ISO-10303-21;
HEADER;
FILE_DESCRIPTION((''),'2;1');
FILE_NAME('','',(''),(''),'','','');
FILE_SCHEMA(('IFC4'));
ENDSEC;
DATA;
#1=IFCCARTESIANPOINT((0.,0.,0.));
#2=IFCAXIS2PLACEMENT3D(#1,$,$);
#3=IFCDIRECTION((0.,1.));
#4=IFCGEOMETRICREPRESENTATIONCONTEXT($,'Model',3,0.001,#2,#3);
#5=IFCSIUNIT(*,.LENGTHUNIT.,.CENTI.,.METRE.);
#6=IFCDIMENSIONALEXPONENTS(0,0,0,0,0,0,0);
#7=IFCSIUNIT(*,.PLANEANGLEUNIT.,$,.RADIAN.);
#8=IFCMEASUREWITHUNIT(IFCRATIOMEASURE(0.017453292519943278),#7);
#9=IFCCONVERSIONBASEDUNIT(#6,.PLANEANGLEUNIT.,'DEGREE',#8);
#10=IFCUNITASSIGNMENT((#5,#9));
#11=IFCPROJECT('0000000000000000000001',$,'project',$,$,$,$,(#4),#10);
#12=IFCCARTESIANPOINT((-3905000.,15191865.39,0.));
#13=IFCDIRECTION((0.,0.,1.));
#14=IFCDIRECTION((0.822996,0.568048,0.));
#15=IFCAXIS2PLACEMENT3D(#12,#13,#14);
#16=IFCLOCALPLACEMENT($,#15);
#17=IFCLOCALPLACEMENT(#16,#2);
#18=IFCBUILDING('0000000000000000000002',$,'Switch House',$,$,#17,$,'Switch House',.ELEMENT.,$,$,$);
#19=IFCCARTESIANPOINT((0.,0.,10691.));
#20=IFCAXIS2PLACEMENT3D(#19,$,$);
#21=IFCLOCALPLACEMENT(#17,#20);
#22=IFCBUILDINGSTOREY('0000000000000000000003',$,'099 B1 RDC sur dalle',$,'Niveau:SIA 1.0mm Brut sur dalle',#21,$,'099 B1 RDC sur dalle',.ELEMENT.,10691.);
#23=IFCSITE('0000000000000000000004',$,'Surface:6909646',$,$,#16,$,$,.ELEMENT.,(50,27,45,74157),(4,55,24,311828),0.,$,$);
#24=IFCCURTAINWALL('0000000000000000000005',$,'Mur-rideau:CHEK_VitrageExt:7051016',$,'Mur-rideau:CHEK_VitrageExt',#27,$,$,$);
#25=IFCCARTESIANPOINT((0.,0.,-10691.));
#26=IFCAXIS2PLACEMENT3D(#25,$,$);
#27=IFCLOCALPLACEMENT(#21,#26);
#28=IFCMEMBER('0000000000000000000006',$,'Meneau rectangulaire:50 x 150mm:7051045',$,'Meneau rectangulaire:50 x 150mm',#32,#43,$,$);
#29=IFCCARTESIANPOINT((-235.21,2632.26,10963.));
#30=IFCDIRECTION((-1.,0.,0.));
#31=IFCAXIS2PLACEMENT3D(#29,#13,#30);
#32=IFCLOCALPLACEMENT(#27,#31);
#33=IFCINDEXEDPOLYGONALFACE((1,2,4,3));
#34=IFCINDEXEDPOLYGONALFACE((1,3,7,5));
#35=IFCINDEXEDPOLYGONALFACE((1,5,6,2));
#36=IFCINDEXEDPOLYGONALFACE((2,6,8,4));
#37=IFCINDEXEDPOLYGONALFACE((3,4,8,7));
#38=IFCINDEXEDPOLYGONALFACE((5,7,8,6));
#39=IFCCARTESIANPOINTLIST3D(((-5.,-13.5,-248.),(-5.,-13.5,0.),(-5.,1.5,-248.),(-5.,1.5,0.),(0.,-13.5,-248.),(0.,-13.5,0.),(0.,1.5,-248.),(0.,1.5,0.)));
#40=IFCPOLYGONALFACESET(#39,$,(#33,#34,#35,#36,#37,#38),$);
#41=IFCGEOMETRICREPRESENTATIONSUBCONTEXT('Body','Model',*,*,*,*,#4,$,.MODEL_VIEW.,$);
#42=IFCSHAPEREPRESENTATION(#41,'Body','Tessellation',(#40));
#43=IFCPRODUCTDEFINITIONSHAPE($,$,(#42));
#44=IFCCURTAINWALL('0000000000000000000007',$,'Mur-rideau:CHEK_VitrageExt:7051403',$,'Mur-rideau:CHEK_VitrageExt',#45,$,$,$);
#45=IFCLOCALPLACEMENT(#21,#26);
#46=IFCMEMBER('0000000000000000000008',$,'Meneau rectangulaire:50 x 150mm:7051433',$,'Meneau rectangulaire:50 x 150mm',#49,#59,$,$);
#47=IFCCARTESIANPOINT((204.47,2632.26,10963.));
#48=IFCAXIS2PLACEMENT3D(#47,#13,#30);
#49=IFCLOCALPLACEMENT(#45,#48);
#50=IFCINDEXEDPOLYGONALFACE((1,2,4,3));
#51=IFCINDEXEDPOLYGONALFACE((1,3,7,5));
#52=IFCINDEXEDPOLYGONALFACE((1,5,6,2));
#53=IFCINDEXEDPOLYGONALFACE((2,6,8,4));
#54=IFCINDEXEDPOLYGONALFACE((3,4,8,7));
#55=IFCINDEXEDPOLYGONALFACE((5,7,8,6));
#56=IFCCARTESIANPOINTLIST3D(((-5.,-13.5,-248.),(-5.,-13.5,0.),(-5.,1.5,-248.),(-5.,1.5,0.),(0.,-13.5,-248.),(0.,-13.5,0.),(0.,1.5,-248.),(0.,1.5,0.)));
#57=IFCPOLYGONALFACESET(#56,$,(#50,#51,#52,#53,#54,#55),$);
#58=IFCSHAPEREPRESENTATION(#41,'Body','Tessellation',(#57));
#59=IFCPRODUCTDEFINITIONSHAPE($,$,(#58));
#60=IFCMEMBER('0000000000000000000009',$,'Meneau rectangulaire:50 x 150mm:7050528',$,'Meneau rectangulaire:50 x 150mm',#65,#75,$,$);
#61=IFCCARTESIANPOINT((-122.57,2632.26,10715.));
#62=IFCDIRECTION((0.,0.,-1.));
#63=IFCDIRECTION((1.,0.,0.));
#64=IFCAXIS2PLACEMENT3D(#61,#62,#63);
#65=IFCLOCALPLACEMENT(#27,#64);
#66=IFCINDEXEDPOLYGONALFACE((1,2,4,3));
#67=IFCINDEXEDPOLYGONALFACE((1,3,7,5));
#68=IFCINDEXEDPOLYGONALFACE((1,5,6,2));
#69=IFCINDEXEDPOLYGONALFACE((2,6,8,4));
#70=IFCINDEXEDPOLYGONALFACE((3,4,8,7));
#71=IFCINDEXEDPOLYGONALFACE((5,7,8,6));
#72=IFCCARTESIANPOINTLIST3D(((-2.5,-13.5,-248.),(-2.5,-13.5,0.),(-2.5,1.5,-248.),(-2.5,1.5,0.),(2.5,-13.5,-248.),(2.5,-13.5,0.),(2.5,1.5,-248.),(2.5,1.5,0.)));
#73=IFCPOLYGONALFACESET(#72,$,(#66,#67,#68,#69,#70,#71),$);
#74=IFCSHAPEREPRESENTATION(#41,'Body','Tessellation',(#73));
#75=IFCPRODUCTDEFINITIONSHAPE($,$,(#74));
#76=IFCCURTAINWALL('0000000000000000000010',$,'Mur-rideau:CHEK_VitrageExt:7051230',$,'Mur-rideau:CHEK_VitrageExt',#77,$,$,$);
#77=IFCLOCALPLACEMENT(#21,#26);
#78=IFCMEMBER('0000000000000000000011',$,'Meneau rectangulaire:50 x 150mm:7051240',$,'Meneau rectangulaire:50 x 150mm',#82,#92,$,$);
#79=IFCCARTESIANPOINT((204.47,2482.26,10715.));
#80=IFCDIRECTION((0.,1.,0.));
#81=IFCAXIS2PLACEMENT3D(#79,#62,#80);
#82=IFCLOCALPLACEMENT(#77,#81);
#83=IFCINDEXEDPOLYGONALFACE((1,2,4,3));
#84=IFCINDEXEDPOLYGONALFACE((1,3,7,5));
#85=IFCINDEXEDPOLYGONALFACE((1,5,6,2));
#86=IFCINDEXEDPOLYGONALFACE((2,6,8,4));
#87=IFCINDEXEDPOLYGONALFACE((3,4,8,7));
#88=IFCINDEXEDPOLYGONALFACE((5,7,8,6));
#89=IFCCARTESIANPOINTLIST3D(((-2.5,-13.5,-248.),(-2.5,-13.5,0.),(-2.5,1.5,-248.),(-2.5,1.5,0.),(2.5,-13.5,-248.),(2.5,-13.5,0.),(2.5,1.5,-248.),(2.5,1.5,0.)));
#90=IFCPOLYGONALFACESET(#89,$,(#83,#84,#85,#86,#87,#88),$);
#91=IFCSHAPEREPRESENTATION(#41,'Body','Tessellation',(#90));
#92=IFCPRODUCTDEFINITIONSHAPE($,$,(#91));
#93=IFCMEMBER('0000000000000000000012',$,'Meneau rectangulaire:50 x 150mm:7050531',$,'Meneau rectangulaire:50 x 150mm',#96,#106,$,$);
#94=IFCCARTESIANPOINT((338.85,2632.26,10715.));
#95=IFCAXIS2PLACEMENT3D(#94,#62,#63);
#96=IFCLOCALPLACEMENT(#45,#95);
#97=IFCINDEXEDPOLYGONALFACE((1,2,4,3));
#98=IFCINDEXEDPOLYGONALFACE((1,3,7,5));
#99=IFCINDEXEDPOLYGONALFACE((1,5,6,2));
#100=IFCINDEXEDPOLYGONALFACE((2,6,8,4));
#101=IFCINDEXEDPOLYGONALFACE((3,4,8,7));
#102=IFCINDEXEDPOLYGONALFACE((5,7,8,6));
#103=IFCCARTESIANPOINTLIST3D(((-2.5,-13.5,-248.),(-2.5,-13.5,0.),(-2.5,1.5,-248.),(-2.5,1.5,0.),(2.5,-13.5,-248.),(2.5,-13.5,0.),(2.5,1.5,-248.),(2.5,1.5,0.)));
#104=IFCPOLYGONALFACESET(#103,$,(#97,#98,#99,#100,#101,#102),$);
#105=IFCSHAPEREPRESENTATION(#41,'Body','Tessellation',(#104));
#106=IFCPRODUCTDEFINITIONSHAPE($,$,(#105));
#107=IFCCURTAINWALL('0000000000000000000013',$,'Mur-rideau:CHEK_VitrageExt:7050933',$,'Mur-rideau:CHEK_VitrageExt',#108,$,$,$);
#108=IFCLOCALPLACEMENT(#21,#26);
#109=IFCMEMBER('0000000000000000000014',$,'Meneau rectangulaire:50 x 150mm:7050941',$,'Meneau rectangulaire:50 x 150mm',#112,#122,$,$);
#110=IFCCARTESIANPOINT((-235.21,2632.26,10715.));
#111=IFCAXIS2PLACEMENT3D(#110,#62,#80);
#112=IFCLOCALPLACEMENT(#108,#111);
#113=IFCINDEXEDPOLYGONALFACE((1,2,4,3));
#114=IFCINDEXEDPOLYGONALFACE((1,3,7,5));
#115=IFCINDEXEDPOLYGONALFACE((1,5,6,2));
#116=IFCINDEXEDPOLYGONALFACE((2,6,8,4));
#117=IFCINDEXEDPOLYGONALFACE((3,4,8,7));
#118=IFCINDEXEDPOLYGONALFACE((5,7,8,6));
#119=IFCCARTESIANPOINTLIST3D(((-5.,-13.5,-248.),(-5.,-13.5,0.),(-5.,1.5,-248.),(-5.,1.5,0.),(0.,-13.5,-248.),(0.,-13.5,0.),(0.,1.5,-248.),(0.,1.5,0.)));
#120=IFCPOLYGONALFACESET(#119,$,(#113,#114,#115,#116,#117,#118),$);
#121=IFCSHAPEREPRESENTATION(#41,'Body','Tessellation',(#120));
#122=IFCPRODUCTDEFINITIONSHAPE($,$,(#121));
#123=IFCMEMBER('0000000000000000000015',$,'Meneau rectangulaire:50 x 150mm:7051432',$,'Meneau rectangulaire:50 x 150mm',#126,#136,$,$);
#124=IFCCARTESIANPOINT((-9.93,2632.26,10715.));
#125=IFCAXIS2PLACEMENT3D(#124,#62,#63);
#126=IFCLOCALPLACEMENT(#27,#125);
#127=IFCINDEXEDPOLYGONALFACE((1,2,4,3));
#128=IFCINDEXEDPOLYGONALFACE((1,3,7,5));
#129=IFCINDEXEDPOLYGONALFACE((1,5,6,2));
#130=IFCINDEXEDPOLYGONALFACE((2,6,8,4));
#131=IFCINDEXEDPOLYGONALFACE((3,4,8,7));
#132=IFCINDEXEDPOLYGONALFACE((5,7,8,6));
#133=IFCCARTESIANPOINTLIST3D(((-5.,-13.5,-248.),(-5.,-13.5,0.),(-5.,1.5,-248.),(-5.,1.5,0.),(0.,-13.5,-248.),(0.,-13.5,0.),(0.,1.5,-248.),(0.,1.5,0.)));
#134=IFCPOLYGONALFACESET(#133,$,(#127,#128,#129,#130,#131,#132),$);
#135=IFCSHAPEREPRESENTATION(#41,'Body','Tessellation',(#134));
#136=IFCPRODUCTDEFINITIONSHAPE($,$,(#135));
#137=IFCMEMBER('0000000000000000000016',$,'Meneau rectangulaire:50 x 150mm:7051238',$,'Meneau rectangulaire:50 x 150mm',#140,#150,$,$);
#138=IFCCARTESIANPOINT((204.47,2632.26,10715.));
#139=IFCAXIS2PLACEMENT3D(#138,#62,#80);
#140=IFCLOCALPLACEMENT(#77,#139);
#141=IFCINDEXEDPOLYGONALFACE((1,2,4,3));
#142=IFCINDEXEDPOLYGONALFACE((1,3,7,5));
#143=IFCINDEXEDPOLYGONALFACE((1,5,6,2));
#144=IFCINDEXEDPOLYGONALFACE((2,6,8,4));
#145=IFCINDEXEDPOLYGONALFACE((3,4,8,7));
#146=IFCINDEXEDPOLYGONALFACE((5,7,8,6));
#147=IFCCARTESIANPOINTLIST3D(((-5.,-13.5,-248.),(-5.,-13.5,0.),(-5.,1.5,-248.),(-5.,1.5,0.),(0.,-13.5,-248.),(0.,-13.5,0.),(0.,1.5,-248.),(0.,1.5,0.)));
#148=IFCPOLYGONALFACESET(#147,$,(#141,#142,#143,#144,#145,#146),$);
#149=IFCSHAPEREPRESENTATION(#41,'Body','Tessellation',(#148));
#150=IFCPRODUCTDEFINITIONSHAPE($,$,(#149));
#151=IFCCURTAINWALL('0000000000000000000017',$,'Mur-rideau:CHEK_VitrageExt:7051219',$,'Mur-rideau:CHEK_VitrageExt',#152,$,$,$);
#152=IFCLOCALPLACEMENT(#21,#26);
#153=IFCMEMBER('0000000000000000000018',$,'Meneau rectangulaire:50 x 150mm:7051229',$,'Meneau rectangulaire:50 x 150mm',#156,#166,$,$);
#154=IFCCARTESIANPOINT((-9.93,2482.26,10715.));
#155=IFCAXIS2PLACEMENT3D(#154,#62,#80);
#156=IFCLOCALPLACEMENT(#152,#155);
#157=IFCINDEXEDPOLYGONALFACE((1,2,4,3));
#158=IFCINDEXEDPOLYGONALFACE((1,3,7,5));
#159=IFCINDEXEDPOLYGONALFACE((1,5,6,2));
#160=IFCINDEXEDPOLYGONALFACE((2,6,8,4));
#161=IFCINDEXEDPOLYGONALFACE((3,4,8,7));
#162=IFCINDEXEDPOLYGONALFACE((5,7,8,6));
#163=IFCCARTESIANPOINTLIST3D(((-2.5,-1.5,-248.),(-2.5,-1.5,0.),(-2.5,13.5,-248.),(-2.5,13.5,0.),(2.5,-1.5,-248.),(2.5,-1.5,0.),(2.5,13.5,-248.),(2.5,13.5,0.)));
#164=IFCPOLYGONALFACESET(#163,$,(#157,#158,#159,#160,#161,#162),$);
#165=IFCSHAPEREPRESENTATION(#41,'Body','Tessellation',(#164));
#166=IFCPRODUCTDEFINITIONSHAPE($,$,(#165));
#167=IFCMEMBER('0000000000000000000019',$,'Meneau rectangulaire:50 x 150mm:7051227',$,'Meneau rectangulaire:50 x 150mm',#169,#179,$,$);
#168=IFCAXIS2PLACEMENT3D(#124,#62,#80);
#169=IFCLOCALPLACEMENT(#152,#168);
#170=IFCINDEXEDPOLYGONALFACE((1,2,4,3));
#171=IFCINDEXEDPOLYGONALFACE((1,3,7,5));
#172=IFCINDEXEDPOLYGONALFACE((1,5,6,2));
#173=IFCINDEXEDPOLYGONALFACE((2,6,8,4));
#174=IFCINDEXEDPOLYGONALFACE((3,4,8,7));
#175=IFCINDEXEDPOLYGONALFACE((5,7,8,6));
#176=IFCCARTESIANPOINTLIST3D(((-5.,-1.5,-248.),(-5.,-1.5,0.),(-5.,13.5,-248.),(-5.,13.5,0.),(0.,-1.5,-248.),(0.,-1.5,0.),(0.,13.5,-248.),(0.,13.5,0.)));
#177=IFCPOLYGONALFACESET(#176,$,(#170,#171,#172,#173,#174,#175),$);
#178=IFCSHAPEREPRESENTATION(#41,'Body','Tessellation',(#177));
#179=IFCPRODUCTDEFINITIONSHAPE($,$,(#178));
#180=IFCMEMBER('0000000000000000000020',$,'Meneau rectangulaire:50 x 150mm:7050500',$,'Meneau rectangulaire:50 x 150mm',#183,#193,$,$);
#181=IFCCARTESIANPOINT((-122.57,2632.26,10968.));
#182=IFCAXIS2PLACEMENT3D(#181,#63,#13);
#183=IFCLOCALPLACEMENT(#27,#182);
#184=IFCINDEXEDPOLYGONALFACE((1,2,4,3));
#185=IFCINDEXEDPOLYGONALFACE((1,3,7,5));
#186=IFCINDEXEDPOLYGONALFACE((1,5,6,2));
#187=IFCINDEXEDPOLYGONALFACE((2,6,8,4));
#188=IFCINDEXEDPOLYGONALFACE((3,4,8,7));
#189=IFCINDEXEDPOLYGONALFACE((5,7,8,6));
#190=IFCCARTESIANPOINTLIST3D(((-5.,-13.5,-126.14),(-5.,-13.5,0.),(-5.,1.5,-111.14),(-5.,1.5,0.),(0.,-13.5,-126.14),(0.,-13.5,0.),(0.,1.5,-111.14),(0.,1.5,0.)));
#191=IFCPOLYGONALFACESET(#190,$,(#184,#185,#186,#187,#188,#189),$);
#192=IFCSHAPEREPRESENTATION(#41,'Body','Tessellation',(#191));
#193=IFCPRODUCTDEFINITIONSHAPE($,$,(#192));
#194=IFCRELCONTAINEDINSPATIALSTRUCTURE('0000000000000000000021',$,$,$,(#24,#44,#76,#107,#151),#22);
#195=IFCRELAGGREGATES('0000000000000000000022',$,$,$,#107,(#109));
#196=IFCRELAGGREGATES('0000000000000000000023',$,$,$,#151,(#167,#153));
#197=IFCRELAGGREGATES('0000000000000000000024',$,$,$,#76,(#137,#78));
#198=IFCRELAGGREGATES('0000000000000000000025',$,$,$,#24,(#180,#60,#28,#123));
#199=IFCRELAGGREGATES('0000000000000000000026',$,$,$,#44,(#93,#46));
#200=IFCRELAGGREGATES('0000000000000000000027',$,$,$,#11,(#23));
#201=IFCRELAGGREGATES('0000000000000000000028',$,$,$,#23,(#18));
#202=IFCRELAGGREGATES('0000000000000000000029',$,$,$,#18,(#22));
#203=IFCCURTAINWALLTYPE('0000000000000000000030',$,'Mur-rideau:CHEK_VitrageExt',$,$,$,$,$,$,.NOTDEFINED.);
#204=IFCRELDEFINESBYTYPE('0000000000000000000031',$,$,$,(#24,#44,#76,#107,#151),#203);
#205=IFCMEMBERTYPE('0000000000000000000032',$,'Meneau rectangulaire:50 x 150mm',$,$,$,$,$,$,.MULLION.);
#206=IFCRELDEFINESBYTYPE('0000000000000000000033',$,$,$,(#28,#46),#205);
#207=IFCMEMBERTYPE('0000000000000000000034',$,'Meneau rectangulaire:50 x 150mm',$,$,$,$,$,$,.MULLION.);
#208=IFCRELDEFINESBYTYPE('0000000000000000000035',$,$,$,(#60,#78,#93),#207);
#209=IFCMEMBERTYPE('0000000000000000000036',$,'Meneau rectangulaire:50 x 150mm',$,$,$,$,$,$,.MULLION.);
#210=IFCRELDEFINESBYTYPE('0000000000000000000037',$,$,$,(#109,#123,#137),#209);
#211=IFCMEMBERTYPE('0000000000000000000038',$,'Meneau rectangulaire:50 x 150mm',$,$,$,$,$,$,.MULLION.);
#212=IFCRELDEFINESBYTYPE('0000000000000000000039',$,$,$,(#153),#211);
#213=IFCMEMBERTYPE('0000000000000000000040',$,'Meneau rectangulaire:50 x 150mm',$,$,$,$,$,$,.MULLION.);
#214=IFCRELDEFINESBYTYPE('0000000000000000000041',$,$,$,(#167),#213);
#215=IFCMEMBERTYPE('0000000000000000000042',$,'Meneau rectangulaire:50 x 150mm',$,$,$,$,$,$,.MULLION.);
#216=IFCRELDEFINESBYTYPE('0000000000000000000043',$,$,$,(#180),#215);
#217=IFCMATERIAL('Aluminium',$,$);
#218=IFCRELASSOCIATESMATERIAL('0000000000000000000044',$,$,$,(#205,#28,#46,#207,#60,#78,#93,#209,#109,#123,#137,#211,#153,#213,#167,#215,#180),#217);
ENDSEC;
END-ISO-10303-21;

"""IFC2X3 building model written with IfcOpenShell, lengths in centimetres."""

from ifc_helpers import new_model, entity, si_unit, converted_unit, direction, frame, origin, origin_2d_with_axis, place, context, subcontext, project, spatial, rectangle, extrude, clip, halfspace, source, transform, mapped, material, type_object, type_shapes, element, aggregate, save


model = new_model("IFC2X3")

# Units and contexts
model_context = context("Model", 3, precision=0.001, world=origin(), true_north=direction((0.0, 1.0)))
body_context = subcontext(model_context, "Body", "Model", "MODEL_VIEW")
ifc_project = project(units=[si_unit("LENGTHUNIT", "METRE", prefix="CENTI"), converted_unit("PLANEANGLEUNIT", "DEGREE", entity("IfcRatioMeasure", 0.017453292519943278), si_unit("PLANEANGLEUNIT", "RADIAN"), dimensions=[0, 0, 0, 0, 0, 0, 0])], contexts=[model_context])

# Site, building, storey
site_placement = place(None, frame((-3905000.0, 15191865.39, 0.0), z_axis=(0.0, 0.0, 1.0), x_axis=(0.822996, 0.568048, 0.0)))
site = spatial("IfcSite", under=ifc_project, at=site_placement, Name="Surface:6909646", CompositionType="ELEMENT", RefLatitude=(50, 27, 45, 74157), RefLongitude=(4, 55, 24, 311828), RefElevation=0.0)
building_placement = place(site_placement, origin())
building = spatial("IfcBuilding", under=site, at=building_placement, Name="Switch House", LongName="Switch House", CompositionType="ELEMENT")
storey_placement = place(building_placement, frame((0.0, 0.0, 10691.0)))
storey = spatial("IfcBuildingStorey", under=building, at=storey_placement, Name="099 B1 RDC sur dalle", ObjectType="Niveau:SIA 1.0mm Brut sur dalle", LongName="099 B1 RDC sur dalle", CompositionType="ELEMENT", Elevation=10691.0)

# Curtain walls, members
curtain_wall_type = type_object("IfcCurtainWallType", Name="Mur-rideau:CHEK_VitrageExt", PredefinedType="NOTDEFINED")
curtain_wall_1_placement = place(storey_placement, frame((0.0, 0.0, -10691.0)))
curtain_wall_1 = element("IfcCurtainWall", 1, at=curtain_wall_1_placement, inside=storey, type_object=curtain_wall_type, Name="Mur-rideau:CHEK_VitrageExt:7051016", ObjectType="Mur-rideau:CHEK_VitrageExt")
ifc_material_1 = material(Name="Aluminium")
member_type_1 = type_object("IfcMemberType", Name="Meneau rectangulaire:50 x 150mm", PredefinedType="MULLION", material=ifc_material_1)
shared_shape_1 = source(origin(), body_context, "Body", "SweptSolid", [
    extrude(rectangle(XDim=15.0, YDim=5.0, at=origin_2d_with_axis()), frame((-2.5, -6.0, -248.0), z_axis=(0.0, 0.0, 1.0), x_axis=(0.0, -1.0, 0.0)), (0.0, 0.0, 1.0), 248.0),
])
type_shapes(member_type_1, [shared_shape_1])
member_1_placement = place(curtain_wall_1_placement, frame((-235.21, 2632.26, 10963.0), z_axis=(0.0, 0.0, 1.0), x_axis=(-1.0, 0.0, 0.0)))
member_1 = element("IfcMember", 2, at=member_1_placement, type_object=member_type_1, material=ifc_material_1, Name="Meneau rectangulaire:50 x 150mm:7051045", ObjectType="Meneau rectangulaire:50 x 150mm", context=body_context, shape_type="MappedRepresentation", body=[
    mapped(shared_shape_1, transform((0.0, 0.0, 0.0), scale=1.0)),
])
curtain_wall_2_placement = place(storey_placement, frame((0.0, 0.0, -10691.0)))
curtain_wall_2 = element("IfcCurtainWall", 3, at=curtain_wall_2_placement, inside=storey, type_object=curtain_wall_type, Name="Mur-rideau:CHEK_VitrageExt:7051403", ObjectType="Mur-rideau:CHEK_VitrageExt")
member_2_placement = place(curtain_wall_2_placement, frame((204.47, 2632.26, 10963.0), z_axis=(0.0, 0.0, 1.0), x_axis=(-1.0, 0.0, 0.0)))
member_2 = element("IfcMember", 4, at=member_2_placement, type_object=member_type_1, material=ifc_material_1, Name="Meneau rectangulaire:50 x 150mm:7051433", ObjectType="Meneau rectangulaire:50 x 150mm", context=body_context, shape_type="MappedRepresentation", body=[
    mapped(shared_shape_1, transform((0.0, 0.0, 0.0), scale=1.0)),
])

# Member
member_type_2 = type_object("IfcMemberType", Name="Meneau rectangulaire:50 x 150mm", PredefinedType="MULLION", material=ifc_material_1)
shared_shape_2 = source(origin(), body_context, "Body", "SweptSolid", [
    extrude(rectangle(XDim=15.0, YDim=5.0, at=origin_2d_with_axis()), frame((0.0, -6.0, -248.0), z_axis=(0.0, 0.0, 1.0), x_axis=(0.0, -1.0, 0.0)), (0.0, 0.0, 1.0), 248.0),
])
type_shapes(member_type_2, [shared_shape_2])
member_3_placement = place(curtain_wall_1_placement, frame((-122.57, 2632.26, 10715.0), z_axis=(0.0, 0.0, -1.0), x_axis=(1.0, 0.0, 0.0)))
member_3 = element("IfcMember", 5, at=member_3_placement, type_object=member_type_2, material=ifc_material_1, Name="Meneau rectangulaire:50 x 150mm:7050528", ObjectType="Meneau rectangulaire:50 x 150mm", context=body_context, shape_type="MappedRepresentation", body=[
    mapped(shared_shape_2, transform((0.0, 0.0, 0.0), scale=1.0)),
])

# Curtain wall, member
curtain_wall_3_placement = place(storey_placement, frame((0.0, 0.0, -10691.0)))
curtain_wall_3 = element("IfcCurtainWall", 6, at=curtain_wall_3_placement, inside=storey, type_object=curtain_wall_type, Name="Mur-rideau:CHEK_VitrageExt:7051230", ObjectType="Mur-rideau:CHEK_VitrageExt")
member_4_placement = place(curtain_wall_3_placement, frame((204.47, 2482.26, 10715.0), z_axis=(0.0, 0.0, -1.0), x_axis=(0.0, 1.0, 0.0)))
member_4 = element("IfcMember", 7, at=member_4_placement, type_object=member_type_2, material=ifc_material_1, Name="Meneau rectangulaire:50 x 150mm:7051240", ObjectType="Meneau rectangulaire:50 x 150mm", context=body_context, shape_type="MappedRepresentation", body=[
    mapped(shared_shape_2, transform((0.0, 0.0, 0.0), scale=1.0)),
])

# Member
member_5_placement = place(curtain_wall_2_placement, frame((338.85, 2632.26, 10715.0), z_axis=(0.0, 0.0, -1.0), x_axis=(1.0, 0.0, 0.0)))
member_5 = element("IfcMember", 8, at=member_5_placement, type_object=member_type_2, material=ifc_material_1, Name="Meneau rectangulaire:50 x 150mm:7050531", ObjectType="Meneau rectangulaire:50 x 150mm", context=body_context, shape_type="MappedRepresentation", body=[
    mapped(shared_shape_2, transform((0.0, 0.0, 0.0), scale=1.0)),
])

# Curtain wall, member
curtain_wall_4_placement = place(storey_placement, frame((0.0, 0.0, -10691.0)))
curtain_wall_4 = element("IfcCurtainWall", 9, at=curtain_wall_4_placement, inside=storey, type_object=curtain_wall_type, Name="Mur-rideau:CHEK_VitrageExt:7050933", ObjectType="Mur-rideau:CHEK_VitrageExt")
member_type_3 = type_object("IfcMemberType", Name="Meneau rectangulaire:50 x 150mm", PredefinedType="MULLION", material=ifc_material_1)
shared_shape_3 = source(origin(), body_context, "Body", "SweptSolid", [
    extrude(rectangle(XDim=15.0, YDim=5.0, at=origin_2d_with_axis()), frame((-2.5, -6.0, -248.0), z_axis=(0.0, 0.0, 1.0), x_axis=(0.0, -1.0, 0.0)), (0.0, 0.0, 1.0), 248.0),
])
type_shapes(member_type_3, [shared_shape_3])
member_6_placement = place(curtain_wall_4_placement, frame((-235.21, 2632.26, 10715.0), z_axis=(0.0, 0.0, -1.0), x_axis=(0.0, 1.0, 0.0)))
member_6 = element("IfcMember", 10, at=member_6_placement, type_object=member_type_3, material=ifc_material_1, Name="Meneau rectangulaire:50 x 150mm:7050941", ObjectType="Meneau rectangulaire:50 x 150mm", context=body_context, shape_type="MappedRepresentation", body=[
    mapped(shared_shape_3, transform((0.0, 0.0, 0.0), scale=1.0)),
])
aggregate(curtain_wall_4, [member_6])

# Members
member_7_placement = place(curtain_wall_1_placement, frame((-9.93, 2632.26, 10715.0), z_axis=(0.0, 0.0, -1.0), x_axis=(1.0, 0.0, 0.0)))
member_7 = element("IfcMember", 11, at=member_7_placement, type_object=member_type_3, material=ifc_material_1, Name="Meneau rectangulaire:50 x 150mm:7051432", ObjectType="Meneau rectangulaire:50 x 150mm", context=body_context, shape_type="MappedRepresentation", body=[
    mapped(shared_shape_3, transform((0.0, 0.0, 0.0), scale=1.0)),
])
member_8_placement = place(curtain_wall_3_placement, frame((204.47, 2632.26, 10715.0), z_axis=(0.0, 0.0, -1.0), x_axis=(0.0, 1.0, 0.0)))
member_8 = element("IfcMember", 12, at=member_8_placement, type_object=member_type_3, material=ifc_material_1, Name="Meneau rectangulaire:50 x 150mm:7051238", ObjectType="Meneau rectangulaire:50 x 150mm", context=body_context, shape_type="MappedRepresentation", body=[
    mapped(shared_shape_3, transform((0.0, 0.0, 0.0), scale=1.0)),
])

# Curtain wall, members
curtain_wall_5_placement = place(storey_placement, frame((0.0, 0.0, -10691.0)))
curtain_wall_5 = element("IfcCurtainWall", 13, at=curtain_wall_5_placement, inside=storey, type_object=curtain_wall_type, Name="Mur-rideau:CHEK_VitrageExt:7051219", ObjectType="Mur-rideau:CHEK_VitrageExt")
member_type_4 = type_object("IfcMemberType", Name="Meneau rectangulaire:50 x 150mm", PredefinedType="MULLION", material=ifc_material_1)
shared_shape_4 = source(origin(), body_context, "Body", "SweptSolid", [
    extrude(rectangle(XDim=15.0, YDim=5.0, at=origin_2d_with_axis()), frame((0.0, 6.0, -248.0), z_axis=(0.0, 0.0, 1.0), x_axis=(0.0, -1.0, 0.0)), (0.0, 0.0, 1.0), 248.0),
])
type_shapes(member_type_4, [shared_shape_4])
member_9_placement = place(curtain_wall_5_placement, frame((-9.93, 2482.26, 10715.0), z_axis=(0.0, 0.0, -1.0), x_axis=(0.0, 1.0, 0.0)))
member_9 = element("IfcMember", 14, at=member_9_placement, type_object=member_type_4, material=ifc_material_1, Name="Meneau rectangulaire:50 x 150mm:7051229", ObjectType="Meneau rectangulaire:50 x 150mm", context=body_context, shape_type="MappedRepresentation", body=[
    mapped(shared_shape_4, transform((0.0, 0.0, 0.0), scale=1.0)),
])
member_type_5 = type_object("IfcMemberType", Name="Meneau rectangulaire:50 x 150mm", PredefinedType="MULLION", material=ifc_material_1)
shared_shape_5 = source(origin(), body_context, "Body", "SweptSolid", [
    extrude(rectangle(XDim=15.0, YDim=5.0, at=origin_2d_with_axis()), frame((-2.5, 6.0, -248.0), z_axis=(0.0, 0.0, 1.0), x_axis=(0.0, -1.0, 0.0)), (0.0, 0.0, 1.0), 248.0),
])
type_shapes(member_type_5, [shared_shape_5])
member_10_placement = place(curtain_wall_5_placement, frame((-9.93, 2632.26, 10715.0), z_axis=(0.0, 0.0, -1.0), x_axis=(0.0, 1.0, 0.0)))
member_10 = element("IfcMember", 15, at=member_10_placement, type_object=member_type_5, material=ifc_material_1, Name="Meneau rectangulaire:50 x 150mm:7051227", ObjectType="Meneau rectangulaire:50 x 150mm", context=body_context, shape_type="MappedRepresentation", body=[
    mapped(shared_shape_5, transform((0.0, 0.0, 0.0), scale=1.0)),
])

# Member
member_type_6 = type_object("IfcMemberType", Name="Meneau rectangulaire:50 x 150mm", PredefinedType="MULLION", material=ifc_material_1)
shared_shape_6 = source(origin(), body_context, "Body", "SweptSolid", [
    clip(extrude(rectangle(XDim=15.0, YDim=5.0, at=origin_2d_with_axis()), frame((-2.5, -6.0, -126.14), z_axis=(0.0, 0.0, 1.0), x_axis=(0.0, -1.0, 0.0)), (0.0, 0.0, 1.0), 126.14), halfspace(frame((-30.48, 0.0, -112.64), z_axis=(0.0, 0.707107, -0.707107), x_axis=(0.0, 0.707107, 0.707107)), False)),
])
type_shapes(member_type_6, [shared_shape_6])
member_11_placement = place(curtain_wall_1_placement, frame((-122.57, 2632.26, 10968.0), z_axis=(1.0, 0.0, 0.0), x_axis=(0.0, 0.0, 1.0)))
member_11 = element("IfcMember", 16, at=member_11_placement, type_object=member_type_6, material=ifc_material_1, Name="Meneau rectangulaire:50 x 150mm:7050500", ObjectType="Meneau rectangulaire:50 x 150mm", context=body_context, shape_type="MappedRepresentation", body=[
    mapped(shared_shape_6, transform((0.0, 0.0, 0.0), scale=1.0)),
])

aggregate(curtain_wall_5, [member_10, member_9])
aggregate(curtain_wall_3, [member_8, member_4])
aggregate(curtain_wall_1, [member_11, member_3, member_1, member_7])
aggregate(curtain_wall_2, [member_5, member_2])

save(model, "model.ifc")
